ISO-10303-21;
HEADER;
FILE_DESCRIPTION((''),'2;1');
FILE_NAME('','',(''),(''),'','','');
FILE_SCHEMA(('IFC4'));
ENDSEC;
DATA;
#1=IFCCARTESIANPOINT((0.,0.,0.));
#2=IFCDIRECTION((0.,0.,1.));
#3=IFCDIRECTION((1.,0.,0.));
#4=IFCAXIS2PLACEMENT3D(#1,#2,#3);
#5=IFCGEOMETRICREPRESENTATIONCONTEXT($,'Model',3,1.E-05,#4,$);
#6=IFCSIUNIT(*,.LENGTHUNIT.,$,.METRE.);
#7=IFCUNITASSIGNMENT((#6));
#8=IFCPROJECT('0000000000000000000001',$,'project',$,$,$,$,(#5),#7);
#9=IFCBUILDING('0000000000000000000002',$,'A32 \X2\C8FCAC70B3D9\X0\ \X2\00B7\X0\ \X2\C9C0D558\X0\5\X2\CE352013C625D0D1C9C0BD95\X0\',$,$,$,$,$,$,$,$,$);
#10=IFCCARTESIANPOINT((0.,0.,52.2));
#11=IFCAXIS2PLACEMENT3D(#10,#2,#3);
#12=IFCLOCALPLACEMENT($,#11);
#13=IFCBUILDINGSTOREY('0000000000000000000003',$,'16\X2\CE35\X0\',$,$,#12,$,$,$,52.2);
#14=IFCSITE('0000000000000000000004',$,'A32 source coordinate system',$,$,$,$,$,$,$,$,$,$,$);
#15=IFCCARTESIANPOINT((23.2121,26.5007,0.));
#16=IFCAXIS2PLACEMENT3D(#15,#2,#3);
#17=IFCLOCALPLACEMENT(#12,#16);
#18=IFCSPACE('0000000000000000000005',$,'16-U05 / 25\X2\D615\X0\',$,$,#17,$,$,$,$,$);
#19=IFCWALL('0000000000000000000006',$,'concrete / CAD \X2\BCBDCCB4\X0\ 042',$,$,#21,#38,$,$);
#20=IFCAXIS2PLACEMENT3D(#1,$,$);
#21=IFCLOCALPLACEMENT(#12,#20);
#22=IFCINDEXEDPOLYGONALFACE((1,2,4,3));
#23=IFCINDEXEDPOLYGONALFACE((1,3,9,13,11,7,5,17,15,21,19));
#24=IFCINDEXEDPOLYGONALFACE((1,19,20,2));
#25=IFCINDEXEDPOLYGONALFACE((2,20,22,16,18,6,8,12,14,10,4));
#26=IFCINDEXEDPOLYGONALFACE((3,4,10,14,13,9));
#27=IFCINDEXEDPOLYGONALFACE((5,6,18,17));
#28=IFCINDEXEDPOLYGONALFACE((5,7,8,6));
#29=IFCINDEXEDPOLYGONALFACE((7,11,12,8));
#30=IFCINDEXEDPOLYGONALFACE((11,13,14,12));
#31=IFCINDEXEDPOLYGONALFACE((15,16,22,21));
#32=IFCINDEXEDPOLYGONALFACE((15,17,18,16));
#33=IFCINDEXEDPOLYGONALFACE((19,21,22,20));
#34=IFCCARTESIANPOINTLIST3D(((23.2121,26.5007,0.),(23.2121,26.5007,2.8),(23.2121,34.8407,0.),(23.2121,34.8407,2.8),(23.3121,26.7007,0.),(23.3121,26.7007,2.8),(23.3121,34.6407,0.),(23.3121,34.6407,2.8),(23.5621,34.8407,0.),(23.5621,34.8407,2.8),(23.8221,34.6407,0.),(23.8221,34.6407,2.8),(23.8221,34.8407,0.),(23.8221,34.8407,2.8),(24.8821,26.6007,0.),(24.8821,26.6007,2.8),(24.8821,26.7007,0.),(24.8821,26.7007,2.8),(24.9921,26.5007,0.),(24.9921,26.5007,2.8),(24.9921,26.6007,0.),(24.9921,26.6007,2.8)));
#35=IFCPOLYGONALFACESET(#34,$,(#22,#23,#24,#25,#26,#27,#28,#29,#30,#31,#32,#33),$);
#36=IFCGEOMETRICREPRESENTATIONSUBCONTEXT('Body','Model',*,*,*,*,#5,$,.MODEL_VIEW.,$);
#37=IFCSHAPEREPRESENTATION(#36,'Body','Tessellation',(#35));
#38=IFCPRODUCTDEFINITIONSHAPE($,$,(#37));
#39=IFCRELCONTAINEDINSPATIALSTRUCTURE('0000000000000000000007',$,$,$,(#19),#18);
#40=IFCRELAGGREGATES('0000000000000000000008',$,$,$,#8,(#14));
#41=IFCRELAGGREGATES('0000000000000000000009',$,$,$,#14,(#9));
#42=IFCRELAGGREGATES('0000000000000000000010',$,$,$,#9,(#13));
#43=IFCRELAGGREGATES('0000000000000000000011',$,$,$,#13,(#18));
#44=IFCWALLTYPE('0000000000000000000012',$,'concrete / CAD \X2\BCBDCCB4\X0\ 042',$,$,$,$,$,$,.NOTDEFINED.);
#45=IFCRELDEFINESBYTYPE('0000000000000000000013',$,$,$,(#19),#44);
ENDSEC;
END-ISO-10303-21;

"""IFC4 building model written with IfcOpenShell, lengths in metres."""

from ifc_helpers import new_model, si_unit, frame, origin, origin_with_axes, place, context, subcontext, project, spatial, polyline, outline, extrude, source, transform, mapped, type_object, type_shapes, element, save


model = new_model("IFC4")

# Units and contexts
model_context = context("Model", 3, precision=1e-05, world=origin_with_axes())
body_context = subcontext(model_context, "Body", "Model", "MODEL_VIEW")
ifc_project = project(units=[si_unit("LENGTHUNIT", "METRE")], contexts=[model_context])

# Site, building, storey, space
site = spatial("IfcSite", under=ifc_project, Name="A32 source coordinate system")
building = spatial("IfcBuilding", under=site, Name="A32 주거동 · 지하5층–옥탑지붕")
storey_placement = place(None, frame((0.0, 0.0, 52.2), z_axis=(0.0, 0.0, 1.0), x_axis=(1.0, 0.0, 0.0)))
storey = spatial("IfcBuildingStorey", under=building, at=storey_placement, Name="16층", Elevation=52.2)
space_1_placement = place(storey_placement, frame((23.2121, 26.5007, 0.0), z_axis=(0.0, 0.0, 1.0), x_axis=(1.0, 0.0, 0.0)))
space_1 = spatial("IfcSpace", under=storey, at=space_1_placement, Name="16-U05 / 25형")

# Wall
wall_type_1 = type_object("IfcWallType", Name="concrete / CAD 벽체 042", PredefinedType="NOTDEFINED")
shared_shape_1 = source(origin(), body_context, "Body", "SweptSolid", [
    extrude(outline(polyline([(0.1, 8.14), (0.1, 0.2), (1.67, 0.2), (1.67, 0.1), (1.78, 0.1), (1.78, 0.0), (0.0, 0.0), (0.0, 8.34), (0.35, 8.34), (0.35, 8.34), (0.61, 8.34), (0.61, 8.14), (0.1, 8.14)])), origin(), (0.0, 0.0, 1.0), 2.8),
])
type_shapes(wall_type_1, [shared_shape_1])
wall_1_placement = place(space_1_placement, origin_with_axes())
element("IfcWall", 1, at=wall_1_placement, inside=space_1, type_object=wall_type_1, Name="concrete / CAD 벽체 042", context=body_context, shape_type="MappedRepresentation", body=[
    mapped(shared_shape_1, transform((0.0, 0.0, 0.0), scale=1.0)),
])

save(model, "model.ifc")
